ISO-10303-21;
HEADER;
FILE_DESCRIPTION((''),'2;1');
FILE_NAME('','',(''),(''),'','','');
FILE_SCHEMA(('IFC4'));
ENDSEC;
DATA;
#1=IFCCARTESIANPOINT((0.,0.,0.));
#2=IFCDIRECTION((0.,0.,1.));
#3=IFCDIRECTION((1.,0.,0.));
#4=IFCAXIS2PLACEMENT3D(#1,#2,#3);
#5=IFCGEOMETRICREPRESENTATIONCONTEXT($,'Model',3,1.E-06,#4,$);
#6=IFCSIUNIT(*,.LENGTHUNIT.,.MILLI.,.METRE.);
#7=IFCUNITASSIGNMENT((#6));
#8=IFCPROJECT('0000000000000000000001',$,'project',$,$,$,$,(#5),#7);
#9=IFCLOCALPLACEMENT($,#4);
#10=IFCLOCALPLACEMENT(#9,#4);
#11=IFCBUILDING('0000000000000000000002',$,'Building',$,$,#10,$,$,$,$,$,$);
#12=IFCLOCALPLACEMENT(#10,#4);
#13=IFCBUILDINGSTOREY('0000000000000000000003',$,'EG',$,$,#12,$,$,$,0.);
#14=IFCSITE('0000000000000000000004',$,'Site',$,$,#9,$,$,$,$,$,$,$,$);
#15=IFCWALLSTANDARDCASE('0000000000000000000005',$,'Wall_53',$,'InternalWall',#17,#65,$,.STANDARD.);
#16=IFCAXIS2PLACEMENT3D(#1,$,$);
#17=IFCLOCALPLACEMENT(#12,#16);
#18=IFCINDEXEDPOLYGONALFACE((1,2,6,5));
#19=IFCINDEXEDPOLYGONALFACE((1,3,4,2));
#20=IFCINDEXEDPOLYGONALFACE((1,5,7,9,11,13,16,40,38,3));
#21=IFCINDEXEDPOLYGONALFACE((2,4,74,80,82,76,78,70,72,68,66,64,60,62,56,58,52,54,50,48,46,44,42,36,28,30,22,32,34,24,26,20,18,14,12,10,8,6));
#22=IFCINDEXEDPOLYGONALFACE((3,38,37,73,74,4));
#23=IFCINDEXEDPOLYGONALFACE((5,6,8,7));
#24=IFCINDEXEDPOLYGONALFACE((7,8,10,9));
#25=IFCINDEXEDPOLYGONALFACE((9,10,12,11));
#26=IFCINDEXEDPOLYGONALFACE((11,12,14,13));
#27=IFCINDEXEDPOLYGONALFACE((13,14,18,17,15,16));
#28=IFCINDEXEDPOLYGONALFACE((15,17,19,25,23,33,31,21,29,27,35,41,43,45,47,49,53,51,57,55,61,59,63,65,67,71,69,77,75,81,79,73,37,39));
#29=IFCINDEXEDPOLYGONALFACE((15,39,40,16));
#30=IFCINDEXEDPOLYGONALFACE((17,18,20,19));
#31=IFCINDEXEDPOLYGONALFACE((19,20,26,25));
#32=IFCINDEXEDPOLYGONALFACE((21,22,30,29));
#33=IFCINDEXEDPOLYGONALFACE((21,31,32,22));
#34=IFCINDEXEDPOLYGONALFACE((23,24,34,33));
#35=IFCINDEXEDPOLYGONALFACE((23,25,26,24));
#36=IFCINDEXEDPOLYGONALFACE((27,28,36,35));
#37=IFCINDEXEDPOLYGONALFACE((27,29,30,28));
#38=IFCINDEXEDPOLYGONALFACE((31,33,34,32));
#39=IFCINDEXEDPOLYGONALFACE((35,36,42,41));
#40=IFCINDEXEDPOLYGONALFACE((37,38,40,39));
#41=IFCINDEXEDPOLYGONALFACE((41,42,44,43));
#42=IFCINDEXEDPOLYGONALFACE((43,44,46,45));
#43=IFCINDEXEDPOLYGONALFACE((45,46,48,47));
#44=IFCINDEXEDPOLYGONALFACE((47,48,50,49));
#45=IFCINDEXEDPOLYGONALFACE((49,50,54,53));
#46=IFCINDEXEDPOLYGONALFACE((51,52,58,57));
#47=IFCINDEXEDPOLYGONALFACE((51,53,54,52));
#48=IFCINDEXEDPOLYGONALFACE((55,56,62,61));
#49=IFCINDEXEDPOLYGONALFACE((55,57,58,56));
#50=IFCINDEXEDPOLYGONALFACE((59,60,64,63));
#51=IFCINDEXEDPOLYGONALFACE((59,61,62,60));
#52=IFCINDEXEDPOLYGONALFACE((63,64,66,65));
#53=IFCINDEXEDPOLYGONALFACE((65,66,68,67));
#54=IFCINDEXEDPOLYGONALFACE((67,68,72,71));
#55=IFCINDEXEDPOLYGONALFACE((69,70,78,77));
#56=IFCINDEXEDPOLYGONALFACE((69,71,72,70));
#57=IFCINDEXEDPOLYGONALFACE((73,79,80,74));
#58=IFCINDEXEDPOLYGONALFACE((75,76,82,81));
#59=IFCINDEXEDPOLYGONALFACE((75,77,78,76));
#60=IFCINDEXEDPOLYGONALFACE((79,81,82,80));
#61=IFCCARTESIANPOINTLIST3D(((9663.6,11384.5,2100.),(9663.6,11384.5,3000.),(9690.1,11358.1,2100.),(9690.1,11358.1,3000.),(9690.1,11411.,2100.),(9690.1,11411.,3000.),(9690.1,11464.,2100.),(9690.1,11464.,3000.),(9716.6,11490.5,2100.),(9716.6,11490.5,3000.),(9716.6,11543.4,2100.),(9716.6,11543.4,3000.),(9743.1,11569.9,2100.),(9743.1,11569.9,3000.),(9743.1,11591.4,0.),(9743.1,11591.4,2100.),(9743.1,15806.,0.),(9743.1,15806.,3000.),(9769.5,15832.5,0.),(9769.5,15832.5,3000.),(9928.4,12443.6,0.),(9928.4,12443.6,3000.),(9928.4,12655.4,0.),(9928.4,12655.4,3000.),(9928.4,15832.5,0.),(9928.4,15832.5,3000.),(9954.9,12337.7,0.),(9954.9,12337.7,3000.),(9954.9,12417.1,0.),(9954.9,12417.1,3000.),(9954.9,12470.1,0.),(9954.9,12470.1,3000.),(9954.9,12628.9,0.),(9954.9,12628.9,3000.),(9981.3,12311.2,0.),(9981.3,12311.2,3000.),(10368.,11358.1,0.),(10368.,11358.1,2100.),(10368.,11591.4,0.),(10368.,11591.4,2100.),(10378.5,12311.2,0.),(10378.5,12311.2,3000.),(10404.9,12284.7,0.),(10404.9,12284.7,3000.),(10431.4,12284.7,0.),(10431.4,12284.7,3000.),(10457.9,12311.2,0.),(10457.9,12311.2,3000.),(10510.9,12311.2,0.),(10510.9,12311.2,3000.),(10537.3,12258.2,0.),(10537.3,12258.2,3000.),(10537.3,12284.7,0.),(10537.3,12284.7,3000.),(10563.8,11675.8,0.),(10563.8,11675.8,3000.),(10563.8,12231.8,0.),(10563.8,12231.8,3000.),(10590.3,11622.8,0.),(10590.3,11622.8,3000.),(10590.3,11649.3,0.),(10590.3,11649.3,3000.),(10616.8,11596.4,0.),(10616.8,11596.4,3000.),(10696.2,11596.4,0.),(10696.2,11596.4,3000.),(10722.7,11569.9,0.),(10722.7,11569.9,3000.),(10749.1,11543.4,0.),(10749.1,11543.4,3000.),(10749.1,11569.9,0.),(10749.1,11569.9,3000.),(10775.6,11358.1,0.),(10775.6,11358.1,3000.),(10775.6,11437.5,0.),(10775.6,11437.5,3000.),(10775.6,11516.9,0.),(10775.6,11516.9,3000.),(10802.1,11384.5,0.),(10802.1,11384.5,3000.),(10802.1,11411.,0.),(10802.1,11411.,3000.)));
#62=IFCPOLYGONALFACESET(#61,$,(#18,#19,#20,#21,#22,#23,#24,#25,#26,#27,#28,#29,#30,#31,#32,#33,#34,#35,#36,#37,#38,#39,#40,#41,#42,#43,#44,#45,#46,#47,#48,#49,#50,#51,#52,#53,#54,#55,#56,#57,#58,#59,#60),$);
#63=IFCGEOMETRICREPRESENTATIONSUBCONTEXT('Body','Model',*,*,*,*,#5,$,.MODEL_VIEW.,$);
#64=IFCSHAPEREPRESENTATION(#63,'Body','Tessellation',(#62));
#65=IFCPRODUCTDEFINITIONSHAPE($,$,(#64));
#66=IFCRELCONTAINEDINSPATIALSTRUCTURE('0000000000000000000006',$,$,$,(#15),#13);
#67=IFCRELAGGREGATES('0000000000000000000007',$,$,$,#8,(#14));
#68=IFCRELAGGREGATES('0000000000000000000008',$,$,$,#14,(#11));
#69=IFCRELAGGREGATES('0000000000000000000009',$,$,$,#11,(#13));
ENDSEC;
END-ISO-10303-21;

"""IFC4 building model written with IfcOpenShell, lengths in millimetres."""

from ifc_helpers import new_model, si_unit, frame, origin_with_axes, place, context, subcontext, project, spatial, polyline, rectangle, outline, extrude, element, save


model = new_model("IFC4")

# Units and contexts
model_context = context("Model", 3, precision=1e-06, world=origin_with_axes())
body_context = subcontext(model_context, "Body", "Model", "MODEL_VIEW")
ifc_project = project(units=[si_unit("LENGTHUNIT", "METRE", prefix="MILLI")], contexts=[model_context])

# Site, building, storey
site_placement = place(None, origin_with_axes())
site = spatial("IfcSite", under=ifc_project, at=site_placement, Name="Site")
building_placement = place(site_placement, origin_with_axes())
building = spatial("IfcBuilding", under=site, at=building_placement, Name="Building")
storey_placement = place(building_placement, origin_with_axes())
storey = spatial("IfcBuildingStorey", under=building, at=storey_placement, Name="EG", Elevation=0.0)

# Wall, opening
wall_1_placement = place(storey_placement, origin_with_axes())
wall_1 = element("IfcWallStandardCase", 1, at=wall_1_placement, inside=storey, Name="Wall_53", ObjectType="InternalWall", PredefinedType="STANDARD", context=body_context, shape_type="SweptSolid", body=[
    extrude(outline(polyline([(9690.1, 11358.1, 0.0), (9663.6, 11384.5, 0.0), (9690.1, 11411.0, 0.0), (9690.1, 11464.0, 0.0), (9716.6, 11490.5, 0.0), (9716.6, 11543.4, 0.0), (9743.1, 11569.9, 0.0), (9743.1, 15806.0, 0.0), (9769.5, 15832.5, 0.0), (9928.4, 15832.5, 0.0), (9928.4, 12655.4, 0.0), (9954.9, 12628.9, 0.0), (9954.9, 12470.1, 0.0), (9928.4, 12443.6, 0.0), (9954.9, 12417.1, 0.0), (9954.9, 12337.7, 0.0), (9981.3, 12311.2, 0.0), (10378.5, 12311.2, 0.0), (10404.9, 12284.7, 0.0), (10431.4, 12284.7, 0.0), (10457.9, 12311.2, 0.0), (10510.9, 12311.2, 0.0), (10537.3, 12284.7, 0.0), (10537.3, 12258.2, 0.0), (10563.8, 12231.8, 0.0), (10563.8, 11675.8, 0.0), (10590.3, 11649.3, 0.0), (10590.3, 11622.8, 0.0), (10616.8, 11596.4, 0.0), (10696.2, 11596.4, 0.0), (10722.7, 11569.9, 0.0), (10749.1, 11569.9, 0.0), (10749.1, 11543.4, 0.0), (10775.6, 11516.9, 0.0), (10775.6, 11437.5, 0.0), (10802.1, 11411.0, 0.0), (10802.1, 11384.5, 0.0), (10775.6, 11358.1, 0.0), (9690.1, 11358.1, 0.0)])), origin_with_axes(), (0.0, 0.0, 1.0), 3000.0),
])
opening_1_placement = place(wall_1_placement, origin_with_axes())
element("IfcOpeningElement", 2, at=opening_1_placement, inside=storey, cuts=wall_1, context=body_context, shape_type="SweptSolid", body=[
    extrude(rectangle(XDim=1342.1, YDim=400.0), frame((9697.0, 11391.4, 0.0), z_axis=(0.0, 0.0, 1.0), x_axis=(1.0, 0.0, 0.0)), (0.0, 0.0, 1.0), 2100.0),
])

save(model, "model.ifc")
